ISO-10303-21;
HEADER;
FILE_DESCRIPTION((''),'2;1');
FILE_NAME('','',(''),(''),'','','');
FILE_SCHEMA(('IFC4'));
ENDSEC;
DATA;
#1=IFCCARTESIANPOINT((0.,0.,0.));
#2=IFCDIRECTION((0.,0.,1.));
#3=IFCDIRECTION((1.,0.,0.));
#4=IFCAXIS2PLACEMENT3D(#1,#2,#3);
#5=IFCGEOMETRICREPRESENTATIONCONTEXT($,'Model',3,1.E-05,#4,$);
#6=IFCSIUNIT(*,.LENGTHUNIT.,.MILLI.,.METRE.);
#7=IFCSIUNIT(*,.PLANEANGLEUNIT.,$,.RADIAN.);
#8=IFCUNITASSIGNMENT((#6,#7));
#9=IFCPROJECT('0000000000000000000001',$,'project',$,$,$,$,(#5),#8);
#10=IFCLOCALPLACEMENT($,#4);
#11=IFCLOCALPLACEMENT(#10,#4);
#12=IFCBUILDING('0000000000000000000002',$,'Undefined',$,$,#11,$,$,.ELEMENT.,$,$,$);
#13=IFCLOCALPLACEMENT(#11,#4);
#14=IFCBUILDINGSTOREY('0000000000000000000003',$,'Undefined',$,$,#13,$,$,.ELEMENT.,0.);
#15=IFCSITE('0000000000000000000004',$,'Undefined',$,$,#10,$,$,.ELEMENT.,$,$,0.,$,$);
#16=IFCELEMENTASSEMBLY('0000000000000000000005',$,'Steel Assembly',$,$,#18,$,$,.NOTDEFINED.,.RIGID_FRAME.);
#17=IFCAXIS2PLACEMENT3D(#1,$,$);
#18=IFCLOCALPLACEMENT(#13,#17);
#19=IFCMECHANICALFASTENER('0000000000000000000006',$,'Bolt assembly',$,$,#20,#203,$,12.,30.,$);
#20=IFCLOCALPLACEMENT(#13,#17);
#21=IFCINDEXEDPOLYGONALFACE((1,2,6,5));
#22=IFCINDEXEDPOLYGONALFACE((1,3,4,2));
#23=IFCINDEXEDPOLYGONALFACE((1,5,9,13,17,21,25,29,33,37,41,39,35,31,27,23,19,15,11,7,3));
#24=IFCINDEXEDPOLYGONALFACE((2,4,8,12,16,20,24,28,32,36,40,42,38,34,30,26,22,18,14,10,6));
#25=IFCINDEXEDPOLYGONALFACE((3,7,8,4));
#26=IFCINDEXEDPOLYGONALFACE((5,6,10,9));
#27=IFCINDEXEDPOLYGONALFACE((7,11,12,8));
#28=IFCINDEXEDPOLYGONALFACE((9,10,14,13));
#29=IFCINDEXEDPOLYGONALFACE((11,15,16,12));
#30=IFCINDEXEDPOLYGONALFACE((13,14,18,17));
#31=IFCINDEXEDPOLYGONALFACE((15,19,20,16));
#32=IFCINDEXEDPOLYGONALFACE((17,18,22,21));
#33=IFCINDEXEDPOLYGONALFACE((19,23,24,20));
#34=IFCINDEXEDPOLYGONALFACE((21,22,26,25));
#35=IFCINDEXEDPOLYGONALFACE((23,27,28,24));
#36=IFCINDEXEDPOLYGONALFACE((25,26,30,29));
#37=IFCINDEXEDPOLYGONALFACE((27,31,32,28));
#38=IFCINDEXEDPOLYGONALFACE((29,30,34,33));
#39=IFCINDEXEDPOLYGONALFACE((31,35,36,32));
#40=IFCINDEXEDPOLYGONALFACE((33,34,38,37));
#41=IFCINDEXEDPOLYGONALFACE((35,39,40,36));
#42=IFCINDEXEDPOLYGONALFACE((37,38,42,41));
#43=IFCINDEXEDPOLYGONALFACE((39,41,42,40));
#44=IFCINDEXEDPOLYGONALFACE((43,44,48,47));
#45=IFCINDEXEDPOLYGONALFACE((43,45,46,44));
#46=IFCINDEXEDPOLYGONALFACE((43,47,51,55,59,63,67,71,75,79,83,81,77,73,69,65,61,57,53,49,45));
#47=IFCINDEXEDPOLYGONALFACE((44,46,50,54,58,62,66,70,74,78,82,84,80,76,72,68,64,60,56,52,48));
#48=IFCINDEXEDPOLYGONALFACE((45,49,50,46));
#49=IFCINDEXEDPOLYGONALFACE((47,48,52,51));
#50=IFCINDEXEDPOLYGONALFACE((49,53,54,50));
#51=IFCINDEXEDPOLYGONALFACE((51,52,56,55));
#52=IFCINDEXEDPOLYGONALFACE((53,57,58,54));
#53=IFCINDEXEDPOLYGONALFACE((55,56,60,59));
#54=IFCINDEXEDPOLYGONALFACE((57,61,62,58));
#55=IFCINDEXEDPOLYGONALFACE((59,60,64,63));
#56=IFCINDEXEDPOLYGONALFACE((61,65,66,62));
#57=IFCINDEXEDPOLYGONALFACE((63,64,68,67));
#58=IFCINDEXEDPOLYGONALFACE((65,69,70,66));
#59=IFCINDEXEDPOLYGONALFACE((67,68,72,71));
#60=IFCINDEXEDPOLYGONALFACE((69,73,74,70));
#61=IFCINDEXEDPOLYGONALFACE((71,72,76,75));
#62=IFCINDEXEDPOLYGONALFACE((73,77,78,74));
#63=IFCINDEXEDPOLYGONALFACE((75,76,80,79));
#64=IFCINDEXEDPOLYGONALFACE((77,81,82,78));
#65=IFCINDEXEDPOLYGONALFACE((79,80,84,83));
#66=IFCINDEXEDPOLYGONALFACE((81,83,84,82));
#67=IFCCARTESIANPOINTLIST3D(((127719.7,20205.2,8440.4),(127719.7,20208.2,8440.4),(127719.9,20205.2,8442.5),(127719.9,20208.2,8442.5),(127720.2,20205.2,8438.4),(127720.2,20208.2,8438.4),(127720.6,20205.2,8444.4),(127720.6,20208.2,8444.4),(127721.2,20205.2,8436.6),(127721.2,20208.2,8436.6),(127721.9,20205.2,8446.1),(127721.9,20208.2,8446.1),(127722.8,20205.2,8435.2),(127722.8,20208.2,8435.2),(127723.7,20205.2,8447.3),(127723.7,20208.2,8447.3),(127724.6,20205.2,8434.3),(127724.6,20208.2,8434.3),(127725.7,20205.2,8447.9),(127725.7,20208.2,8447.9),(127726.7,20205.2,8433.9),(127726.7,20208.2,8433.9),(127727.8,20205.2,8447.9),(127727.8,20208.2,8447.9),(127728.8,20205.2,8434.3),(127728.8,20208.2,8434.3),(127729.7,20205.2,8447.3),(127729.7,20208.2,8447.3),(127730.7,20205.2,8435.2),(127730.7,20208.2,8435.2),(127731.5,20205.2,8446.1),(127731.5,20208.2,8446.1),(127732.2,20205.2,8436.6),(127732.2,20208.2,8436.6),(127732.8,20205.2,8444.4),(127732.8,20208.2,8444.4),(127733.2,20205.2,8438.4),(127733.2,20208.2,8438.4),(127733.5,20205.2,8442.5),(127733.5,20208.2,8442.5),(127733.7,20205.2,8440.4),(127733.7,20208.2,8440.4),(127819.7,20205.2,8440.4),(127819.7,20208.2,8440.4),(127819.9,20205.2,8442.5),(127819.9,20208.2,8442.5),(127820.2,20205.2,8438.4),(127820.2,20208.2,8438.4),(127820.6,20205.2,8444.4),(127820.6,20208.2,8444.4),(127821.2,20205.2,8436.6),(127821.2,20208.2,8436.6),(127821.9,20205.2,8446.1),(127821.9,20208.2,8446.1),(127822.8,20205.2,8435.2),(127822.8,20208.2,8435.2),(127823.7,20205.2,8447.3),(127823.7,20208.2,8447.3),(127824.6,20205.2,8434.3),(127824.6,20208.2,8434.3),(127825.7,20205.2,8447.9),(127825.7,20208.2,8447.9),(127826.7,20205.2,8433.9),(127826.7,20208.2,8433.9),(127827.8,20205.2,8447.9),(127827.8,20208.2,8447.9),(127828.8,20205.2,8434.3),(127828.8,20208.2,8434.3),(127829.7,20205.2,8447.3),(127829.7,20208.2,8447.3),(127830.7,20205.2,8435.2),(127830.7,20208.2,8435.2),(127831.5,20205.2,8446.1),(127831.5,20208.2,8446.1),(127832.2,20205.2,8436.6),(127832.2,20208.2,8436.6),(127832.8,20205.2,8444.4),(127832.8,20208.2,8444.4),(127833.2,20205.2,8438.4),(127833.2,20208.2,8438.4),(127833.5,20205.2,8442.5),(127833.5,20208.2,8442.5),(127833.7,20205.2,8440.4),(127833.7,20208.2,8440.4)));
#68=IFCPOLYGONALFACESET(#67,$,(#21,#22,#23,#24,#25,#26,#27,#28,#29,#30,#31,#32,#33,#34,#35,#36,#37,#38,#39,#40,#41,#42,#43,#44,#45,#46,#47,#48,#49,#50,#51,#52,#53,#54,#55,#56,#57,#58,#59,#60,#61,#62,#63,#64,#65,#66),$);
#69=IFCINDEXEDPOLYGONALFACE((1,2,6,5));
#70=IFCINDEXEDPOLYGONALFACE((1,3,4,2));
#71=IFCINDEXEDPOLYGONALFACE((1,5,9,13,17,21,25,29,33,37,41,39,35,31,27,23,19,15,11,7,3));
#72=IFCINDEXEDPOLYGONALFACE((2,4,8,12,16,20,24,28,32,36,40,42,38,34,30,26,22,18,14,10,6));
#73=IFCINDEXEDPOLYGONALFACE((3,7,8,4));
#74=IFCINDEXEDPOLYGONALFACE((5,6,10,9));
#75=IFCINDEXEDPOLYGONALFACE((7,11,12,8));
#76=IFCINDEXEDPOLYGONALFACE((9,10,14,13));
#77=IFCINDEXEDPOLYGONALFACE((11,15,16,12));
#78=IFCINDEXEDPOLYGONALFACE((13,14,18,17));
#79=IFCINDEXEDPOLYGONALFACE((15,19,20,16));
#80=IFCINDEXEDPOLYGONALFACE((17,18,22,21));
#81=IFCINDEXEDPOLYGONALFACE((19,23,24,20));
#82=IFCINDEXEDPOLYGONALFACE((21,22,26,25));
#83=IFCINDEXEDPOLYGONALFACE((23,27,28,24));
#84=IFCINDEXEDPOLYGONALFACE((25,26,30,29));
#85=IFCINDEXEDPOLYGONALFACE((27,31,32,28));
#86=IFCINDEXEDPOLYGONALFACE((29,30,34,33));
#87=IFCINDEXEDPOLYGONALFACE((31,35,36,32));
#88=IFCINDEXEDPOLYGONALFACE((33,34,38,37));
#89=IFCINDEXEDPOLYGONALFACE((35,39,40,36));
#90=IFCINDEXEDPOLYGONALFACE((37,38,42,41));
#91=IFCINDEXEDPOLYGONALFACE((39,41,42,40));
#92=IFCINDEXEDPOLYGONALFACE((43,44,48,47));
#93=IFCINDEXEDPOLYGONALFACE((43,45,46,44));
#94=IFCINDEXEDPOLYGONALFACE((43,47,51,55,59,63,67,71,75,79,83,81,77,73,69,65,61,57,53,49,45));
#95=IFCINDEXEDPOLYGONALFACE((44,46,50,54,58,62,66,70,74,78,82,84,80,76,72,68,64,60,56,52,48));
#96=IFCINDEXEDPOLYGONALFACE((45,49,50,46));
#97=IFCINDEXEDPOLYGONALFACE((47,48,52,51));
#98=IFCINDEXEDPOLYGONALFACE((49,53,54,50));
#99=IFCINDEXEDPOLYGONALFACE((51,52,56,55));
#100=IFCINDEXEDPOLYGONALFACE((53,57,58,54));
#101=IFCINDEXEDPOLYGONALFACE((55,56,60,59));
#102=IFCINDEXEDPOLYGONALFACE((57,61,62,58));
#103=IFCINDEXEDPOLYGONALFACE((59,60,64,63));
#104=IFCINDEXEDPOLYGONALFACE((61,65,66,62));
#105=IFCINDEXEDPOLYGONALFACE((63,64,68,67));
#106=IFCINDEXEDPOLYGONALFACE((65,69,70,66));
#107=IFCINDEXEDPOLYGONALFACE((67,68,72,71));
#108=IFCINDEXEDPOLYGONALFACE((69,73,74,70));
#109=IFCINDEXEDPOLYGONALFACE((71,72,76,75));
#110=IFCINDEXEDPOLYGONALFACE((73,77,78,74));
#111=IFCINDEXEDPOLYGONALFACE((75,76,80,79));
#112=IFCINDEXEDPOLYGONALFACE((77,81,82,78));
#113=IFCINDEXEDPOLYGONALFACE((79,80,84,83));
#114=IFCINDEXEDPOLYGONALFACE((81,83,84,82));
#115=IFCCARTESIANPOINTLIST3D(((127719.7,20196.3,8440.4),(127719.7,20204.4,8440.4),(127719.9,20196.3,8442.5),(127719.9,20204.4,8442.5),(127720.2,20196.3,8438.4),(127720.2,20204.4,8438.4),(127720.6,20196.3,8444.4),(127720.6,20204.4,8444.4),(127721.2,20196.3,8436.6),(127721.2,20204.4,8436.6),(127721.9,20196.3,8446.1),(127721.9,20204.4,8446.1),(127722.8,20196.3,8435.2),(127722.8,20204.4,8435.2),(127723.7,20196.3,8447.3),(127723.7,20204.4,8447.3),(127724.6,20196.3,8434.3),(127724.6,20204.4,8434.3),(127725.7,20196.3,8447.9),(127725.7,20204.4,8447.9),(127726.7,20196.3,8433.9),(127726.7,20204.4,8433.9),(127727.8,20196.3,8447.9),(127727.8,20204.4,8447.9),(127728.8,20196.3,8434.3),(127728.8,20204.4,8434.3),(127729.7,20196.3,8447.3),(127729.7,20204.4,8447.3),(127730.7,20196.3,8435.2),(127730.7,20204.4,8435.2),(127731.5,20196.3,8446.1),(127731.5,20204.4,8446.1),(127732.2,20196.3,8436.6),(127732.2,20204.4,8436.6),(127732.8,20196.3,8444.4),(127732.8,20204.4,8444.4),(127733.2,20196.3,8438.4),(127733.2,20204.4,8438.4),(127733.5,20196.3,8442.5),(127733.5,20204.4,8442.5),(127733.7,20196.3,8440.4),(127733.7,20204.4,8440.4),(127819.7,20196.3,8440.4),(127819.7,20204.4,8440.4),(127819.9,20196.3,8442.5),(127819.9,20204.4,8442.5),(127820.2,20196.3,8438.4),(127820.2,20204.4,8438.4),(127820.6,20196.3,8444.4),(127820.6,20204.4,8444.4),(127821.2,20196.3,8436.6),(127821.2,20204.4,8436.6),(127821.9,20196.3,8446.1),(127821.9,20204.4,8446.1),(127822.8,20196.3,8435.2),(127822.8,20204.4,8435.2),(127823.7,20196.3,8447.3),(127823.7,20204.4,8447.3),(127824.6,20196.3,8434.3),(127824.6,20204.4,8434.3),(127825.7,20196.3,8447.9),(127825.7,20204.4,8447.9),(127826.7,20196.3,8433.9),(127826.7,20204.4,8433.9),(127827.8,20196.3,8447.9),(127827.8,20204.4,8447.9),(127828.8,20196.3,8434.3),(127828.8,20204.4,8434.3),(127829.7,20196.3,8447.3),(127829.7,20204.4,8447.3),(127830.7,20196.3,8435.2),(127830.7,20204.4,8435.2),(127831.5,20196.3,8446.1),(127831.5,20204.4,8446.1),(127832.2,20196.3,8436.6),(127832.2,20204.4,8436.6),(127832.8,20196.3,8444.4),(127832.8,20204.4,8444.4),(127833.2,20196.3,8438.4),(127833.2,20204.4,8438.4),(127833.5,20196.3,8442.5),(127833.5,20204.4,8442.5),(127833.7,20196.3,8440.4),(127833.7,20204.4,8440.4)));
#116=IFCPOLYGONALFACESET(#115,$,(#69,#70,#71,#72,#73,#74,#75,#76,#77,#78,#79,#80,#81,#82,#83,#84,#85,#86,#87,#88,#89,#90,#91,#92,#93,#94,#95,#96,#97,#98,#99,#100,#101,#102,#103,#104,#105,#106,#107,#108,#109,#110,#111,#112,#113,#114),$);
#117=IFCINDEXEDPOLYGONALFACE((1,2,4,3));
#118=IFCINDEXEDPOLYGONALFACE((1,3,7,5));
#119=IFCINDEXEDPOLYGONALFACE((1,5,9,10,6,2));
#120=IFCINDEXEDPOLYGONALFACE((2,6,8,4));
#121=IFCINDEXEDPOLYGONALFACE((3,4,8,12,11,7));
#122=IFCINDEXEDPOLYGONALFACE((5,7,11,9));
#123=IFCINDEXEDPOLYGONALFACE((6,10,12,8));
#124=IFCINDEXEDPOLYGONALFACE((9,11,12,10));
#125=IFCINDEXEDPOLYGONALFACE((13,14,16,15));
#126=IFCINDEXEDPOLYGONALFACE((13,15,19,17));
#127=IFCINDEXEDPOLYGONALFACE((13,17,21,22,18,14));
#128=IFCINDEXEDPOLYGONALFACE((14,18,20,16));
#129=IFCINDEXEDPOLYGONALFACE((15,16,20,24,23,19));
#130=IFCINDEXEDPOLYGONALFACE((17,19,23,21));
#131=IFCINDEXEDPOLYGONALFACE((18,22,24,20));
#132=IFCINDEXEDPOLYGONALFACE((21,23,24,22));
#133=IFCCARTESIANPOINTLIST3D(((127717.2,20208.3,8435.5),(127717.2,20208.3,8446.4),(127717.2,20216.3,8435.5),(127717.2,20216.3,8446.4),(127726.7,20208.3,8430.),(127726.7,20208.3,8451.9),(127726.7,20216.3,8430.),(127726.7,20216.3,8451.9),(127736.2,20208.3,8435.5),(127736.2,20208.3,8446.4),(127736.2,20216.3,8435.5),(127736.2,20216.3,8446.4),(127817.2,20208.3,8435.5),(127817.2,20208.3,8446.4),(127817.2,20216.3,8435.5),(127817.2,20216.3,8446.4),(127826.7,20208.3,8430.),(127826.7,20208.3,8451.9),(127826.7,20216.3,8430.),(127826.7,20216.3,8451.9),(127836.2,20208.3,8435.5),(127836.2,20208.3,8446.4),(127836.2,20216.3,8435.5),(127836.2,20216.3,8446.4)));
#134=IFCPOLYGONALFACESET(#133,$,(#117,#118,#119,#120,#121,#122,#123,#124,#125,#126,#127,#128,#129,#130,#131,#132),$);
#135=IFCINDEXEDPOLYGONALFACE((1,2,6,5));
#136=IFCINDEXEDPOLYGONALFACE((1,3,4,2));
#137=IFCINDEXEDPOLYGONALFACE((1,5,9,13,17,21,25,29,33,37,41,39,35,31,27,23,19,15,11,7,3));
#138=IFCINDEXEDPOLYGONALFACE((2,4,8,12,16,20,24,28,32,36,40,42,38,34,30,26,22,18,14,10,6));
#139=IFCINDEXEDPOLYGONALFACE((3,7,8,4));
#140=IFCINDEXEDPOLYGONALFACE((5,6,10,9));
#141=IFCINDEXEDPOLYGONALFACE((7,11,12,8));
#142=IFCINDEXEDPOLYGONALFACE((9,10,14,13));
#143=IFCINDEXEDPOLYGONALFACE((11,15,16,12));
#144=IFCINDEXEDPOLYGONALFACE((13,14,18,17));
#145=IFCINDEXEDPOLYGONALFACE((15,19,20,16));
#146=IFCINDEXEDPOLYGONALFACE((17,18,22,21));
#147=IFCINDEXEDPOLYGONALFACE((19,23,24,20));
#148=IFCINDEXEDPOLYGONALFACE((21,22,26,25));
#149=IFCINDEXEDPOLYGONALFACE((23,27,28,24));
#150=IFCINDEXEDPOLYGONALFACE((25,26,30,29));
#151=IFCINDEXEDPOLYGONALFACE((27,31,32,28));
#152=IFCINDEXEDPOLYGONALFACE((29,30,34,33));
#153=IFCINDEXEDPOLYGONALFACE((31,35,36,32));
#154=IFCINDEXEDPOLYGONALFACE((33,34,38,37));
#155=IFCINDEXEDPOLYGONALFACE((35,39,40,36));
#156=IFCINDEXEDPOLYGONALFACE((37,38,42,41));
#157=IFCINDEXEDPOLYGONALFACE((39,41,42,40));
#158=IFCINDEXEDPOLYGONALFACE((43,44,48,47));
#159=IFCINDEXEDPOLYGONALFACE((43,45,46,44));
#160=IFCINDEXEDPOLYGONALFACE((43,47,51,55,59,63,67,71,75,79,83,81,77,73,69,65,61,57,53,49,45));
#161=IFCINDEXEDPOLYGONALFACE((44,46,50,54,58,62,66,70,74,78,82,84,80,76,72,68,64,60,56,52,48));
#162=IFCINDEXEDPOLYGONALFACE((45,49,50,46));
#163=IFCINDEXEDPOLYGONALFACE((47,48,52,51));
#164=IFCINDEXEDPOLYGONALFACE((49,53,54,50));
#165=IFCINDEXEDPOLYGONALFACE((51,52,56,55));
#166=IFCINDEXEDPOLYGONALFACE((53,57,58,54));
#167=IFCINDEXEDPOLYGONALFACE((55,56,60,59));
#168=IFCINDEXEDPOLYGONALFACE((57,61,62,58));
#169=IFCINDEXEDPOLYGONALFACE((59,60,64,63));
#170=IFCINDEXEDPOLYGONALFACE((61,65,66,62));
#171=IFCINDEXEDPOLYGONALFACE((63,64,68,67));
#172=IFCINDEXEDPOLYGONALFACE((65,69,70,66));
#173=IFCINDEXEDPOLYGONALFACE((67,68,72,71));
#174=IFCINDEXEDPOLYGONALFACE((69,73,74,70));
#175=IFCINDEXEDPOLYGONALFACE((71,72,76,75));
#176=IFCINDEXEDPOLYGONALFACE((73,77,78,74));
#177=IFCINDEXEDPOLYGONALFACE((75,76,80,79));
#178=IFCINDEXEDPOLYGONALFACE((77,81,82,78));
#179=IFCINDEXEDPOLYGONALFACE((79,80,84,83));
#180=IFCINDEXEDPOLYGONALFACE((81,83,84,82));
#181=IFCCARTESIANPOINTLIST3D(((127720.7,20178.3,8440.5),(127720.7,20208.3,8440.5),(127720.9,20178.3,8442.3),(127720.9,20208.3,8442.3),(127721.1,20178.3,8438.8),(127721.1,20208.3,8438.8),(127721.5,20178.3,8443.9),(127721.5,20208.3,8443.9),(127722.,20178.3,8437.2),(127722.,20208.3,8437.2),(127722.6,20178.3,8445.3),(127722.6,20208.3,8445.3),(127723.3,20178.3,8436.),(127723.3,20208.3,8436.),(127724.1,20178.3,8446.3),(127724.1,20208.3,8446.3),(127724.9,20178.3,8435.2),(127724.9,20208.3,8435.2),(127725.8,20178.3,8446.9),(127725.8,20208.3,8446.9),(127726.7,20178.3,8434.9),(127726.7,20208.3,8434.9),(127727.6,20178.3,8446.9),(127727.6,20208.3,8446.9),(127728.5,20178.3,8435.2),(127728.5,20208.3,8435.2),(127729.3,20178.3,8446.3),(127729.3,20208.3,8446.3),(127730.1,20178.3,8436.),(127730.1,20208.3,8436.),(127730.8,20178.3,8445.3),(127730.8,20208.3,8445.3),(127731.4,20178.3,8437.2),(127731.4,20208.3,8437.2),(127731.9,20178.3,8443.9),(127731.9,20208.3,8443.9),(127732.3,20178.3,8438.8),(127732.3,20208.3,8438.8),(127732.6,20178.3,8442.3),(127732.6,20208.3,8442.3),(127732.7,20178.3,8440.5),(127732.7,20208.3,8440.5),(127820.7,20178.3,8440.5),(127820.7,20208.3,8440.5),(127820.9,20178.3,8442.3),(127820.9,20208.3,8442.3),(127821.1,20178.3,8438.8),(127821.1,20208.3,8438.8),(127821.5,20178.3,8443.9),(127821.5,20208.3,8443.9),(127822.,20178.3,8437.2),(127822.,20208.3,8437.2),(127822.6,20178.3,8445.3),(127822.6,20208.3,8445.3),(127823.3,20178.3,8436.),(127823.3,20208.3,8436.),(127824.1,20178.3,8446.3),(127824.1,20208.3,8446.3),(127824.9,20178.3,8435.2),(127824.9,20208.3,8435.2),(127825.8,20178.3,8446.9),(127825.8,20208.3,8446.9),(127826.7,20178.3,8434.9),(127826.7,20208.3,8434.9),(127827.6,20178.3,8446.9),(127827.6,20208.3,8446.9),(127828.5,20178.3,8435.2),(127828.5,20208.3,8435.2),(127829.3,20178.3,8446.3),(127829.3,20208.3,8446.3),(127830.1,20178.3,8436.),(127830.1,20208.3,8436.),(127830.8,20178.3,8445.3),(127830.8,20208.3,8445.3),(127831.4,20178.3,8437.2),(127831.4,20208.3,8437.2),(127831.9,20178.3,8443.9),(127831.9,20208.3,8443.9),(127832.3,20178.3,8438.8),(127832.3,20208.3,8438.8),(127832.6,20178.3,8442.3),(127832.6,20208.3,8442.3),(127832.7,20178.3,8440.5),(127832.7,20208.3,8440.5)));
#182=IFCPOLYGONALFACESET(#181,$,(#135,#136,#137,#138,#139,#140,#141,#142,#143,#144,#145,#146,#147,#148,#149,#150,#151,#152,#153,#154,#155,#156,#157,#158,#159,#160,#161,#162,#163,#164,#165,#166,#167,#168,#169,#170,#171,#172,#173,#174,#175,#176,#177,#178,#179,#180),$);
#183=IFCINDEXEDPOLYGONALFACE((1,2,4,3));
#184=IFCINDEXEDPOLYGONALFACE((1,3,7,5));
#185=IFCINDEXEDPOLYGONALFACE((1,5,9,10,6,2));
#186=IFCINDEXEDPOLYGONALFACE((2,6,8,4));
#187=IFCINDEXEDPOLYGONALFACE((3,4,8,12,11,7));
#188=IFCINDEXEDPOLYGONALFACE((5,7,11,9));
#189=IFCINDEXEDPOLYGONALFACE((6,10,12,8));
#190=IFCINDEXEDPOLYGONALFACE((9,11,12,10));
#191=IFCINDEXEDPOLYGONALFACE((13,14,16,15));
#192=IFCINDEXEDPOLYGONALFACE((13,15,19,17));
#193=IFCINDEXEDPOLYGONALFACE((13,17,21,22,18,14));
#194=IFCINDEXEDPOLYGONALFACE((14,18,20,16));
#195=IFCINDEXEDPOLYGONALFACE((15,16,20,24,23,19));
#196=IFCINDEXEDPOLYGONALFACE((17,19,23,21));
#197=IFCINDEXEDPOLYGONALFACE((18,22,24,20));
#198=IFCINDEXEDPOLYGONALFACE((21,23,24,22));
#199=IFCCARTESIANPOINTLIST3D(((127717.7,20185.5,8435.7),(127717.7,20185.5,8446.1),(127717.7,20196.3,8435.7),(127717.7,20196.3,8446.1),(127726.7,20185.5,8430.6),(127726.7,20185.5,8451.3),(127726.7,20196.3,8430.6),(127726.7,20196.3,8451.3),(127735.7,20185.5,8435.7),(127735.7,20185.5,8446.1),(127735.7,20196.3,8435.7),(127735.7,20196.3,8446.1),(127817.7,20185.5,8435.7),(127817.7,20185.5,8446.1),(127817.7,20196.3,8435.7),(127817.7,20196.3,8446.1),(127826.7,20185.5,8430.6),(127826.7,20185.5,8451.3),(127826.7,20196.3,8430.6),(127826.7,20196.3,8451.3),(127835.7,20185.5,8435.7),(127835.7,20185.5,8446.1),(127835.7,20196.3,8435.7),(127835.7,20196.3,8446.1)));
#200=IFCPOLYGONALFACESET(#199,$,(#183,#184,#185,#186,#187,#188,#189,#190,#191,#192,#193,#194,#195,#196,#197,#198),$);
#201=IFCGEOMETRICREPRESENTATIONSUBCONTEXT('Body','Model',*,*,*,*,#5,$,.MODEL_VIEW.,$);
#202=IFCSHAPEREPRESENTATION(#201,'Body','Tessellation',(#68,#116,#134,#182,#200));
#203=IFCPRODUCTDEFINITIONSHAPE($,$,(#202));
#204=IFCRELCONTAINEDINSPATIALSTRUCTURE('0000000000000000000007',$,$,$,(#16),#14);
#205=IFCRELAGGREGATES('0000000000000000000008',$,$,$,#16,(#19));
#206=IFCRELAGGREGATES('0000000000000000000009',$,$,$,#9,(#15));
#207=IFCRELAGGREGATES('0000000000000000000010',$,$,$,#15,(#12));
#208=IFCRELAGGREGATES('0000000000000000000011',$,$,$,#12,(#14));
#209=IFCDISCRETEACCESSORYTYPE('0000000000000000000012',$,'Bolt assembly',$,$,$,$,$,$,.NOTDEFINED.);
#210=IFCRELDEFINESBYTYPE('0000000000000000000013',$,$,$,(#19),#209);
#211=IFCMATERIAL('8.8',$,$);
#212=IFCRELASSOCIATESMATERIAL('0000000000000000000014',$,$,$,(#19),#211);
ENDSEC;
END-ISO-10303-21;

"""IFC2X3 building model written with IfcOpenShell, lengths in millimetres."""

from ifc_helpers import new_model, si_unit, frame, origin_with_axes, origin_2d_with_axis, place, context, subcontext, project, spatial, polyline, circle, outline, extrude, source, transform, mapped, material, type_object, element, aggregate, save


model = new_model("IFC2X3")

# Units and contexts
model_context = context("Model", 3, precision=1e-05, world=origin_with_axes())
body_context = subcontext(model_context, "Body", "Model", "MODEL_VIEW")
ifc_project = project(units=[si_unit("LENGTHUNIT", "METRE", prefix="MILLI"), si_unit("PLANEANGLEUNIT", "RADIAN")], contexts=[model_context])

# Site, building, storey
site_placement = place(None, origin_with_axes())
site = spatial("IfcSite", under=ifc_project, at=site_placement, Name="Undefined", CompositionType="ELEMENT", RefElevation=0.0)
building_placement = place(site_placement, origin_with_axes())
building = spatial("IfcBuilding", under=site, at=building_placement, Name="Undefined", CompositionType="ELEMENT")
storey_placement = place(building_placement, origin_with_axes())
storey = spatial("IfcBuildingStorey", under=building, at=storey_placement, Name="Undefined", CompositionType="ELEMENT", Elevation=0.0)

# Element assembly, mechanical fastener
assembly_1_placement = place(storey_placement, origin_with_axes())
assembly_1 = element("IfcElementAssembly", 1, at=assembly_1_placement, inside=storey, Name="Steel Assembly", AssemblyPlace="NOTDEFINED", PredefinedType="RIGID_FRAME")
ifc_material_1 = material(Name="8.8")
discrete_accessory_type_1 = type_object("IfcDiscreteAccessoryType", Name="Bolt assembly")
shared_shape = source(origin_with_axes(), body_context, "Body", "SweptSolid", [
    extrude(circle(Radius=7.0, at=origin_2d_with_axis()), frame((0.0, -5.9, 0.0), z_axis=(0.0, 1.0, 0.0), x_axis=(1.0, 0.0, 0.0)), (0.0, 0.0, 1.0), 3.0),
    extrude(circle(Radius=7.0, at=origin_2d_with_axis()), frame((0.0, -2.1, 0.0), z_axis=(0.0, 1.0, 0.0), x_axis=(1.0, 0.0, 0.0)), (0.0, 0.0, 1.0), 8.1),
    extrude(outline(polyline([(11.0, 0.0), (5.5, 9.5), (-5.5, 9.5), (-11.0, 0.0), (-5.5, -9.5), (5.5, -9.5), (11.0, 0.0)])), frame((0.0, -14.0, 0.0), z_axis=(0.0, 1.0, 0.0), x_axis=(1.0, 0.0, 0.0)), (0.0, 0.0, 1.0), 8.0),
    extrude(circle(Radius=6.0, at=origin_2d_with_axis()), frame((0.0, -6.0, 0.0), z_axis=(0.0, 1.0, 0.0), x_axis=(1.0, 0.0, 0.0)), (0.0, 0.0, 1.0), 30.0),
    extrude(outline(polyline([(10.4, 0.0), (5.2, 9.0), (-5.2, 9.0), (-10.4, 0.0), (-5.2, -9.0), (5.2, -9.0), (10.4, 0.0)])), frame((0.0, 6.0, 0.0), z_axis=(0.0, 1.0, 0.0), x_axis=(1.0, 0.0, 0.0)), (0.0, 0.0, 1.0), 10.8),
])
mechanical_fastener_placement = place(assembly_1_placement, frame((127776.7, 20202.3, 8490.9), z_axis=(-1.0, 0.0, 0.0), x_axis=(0.0, 0.0, -1.0)))
mechanical_fastener = element("IfcMechanicalFastener", 2, at=mechanical_fastener_placement, type_object=discrete_accessory_type_1, material=ifc_material_1, Name="Bolt assembly", NominalDiameter=12.0, NominalLength=30.0, context=body_context, shape_type="MappedRepresentation", body=[
    mapped(shared_shape, transform((50.0, 0.0, -50.0))),
    mapped(shared_shape, transform((50.0, 0.0, 50.0))),
])
aggregate(assembly_1, [mechanical_fastener])

save(model, "model.ifc")
